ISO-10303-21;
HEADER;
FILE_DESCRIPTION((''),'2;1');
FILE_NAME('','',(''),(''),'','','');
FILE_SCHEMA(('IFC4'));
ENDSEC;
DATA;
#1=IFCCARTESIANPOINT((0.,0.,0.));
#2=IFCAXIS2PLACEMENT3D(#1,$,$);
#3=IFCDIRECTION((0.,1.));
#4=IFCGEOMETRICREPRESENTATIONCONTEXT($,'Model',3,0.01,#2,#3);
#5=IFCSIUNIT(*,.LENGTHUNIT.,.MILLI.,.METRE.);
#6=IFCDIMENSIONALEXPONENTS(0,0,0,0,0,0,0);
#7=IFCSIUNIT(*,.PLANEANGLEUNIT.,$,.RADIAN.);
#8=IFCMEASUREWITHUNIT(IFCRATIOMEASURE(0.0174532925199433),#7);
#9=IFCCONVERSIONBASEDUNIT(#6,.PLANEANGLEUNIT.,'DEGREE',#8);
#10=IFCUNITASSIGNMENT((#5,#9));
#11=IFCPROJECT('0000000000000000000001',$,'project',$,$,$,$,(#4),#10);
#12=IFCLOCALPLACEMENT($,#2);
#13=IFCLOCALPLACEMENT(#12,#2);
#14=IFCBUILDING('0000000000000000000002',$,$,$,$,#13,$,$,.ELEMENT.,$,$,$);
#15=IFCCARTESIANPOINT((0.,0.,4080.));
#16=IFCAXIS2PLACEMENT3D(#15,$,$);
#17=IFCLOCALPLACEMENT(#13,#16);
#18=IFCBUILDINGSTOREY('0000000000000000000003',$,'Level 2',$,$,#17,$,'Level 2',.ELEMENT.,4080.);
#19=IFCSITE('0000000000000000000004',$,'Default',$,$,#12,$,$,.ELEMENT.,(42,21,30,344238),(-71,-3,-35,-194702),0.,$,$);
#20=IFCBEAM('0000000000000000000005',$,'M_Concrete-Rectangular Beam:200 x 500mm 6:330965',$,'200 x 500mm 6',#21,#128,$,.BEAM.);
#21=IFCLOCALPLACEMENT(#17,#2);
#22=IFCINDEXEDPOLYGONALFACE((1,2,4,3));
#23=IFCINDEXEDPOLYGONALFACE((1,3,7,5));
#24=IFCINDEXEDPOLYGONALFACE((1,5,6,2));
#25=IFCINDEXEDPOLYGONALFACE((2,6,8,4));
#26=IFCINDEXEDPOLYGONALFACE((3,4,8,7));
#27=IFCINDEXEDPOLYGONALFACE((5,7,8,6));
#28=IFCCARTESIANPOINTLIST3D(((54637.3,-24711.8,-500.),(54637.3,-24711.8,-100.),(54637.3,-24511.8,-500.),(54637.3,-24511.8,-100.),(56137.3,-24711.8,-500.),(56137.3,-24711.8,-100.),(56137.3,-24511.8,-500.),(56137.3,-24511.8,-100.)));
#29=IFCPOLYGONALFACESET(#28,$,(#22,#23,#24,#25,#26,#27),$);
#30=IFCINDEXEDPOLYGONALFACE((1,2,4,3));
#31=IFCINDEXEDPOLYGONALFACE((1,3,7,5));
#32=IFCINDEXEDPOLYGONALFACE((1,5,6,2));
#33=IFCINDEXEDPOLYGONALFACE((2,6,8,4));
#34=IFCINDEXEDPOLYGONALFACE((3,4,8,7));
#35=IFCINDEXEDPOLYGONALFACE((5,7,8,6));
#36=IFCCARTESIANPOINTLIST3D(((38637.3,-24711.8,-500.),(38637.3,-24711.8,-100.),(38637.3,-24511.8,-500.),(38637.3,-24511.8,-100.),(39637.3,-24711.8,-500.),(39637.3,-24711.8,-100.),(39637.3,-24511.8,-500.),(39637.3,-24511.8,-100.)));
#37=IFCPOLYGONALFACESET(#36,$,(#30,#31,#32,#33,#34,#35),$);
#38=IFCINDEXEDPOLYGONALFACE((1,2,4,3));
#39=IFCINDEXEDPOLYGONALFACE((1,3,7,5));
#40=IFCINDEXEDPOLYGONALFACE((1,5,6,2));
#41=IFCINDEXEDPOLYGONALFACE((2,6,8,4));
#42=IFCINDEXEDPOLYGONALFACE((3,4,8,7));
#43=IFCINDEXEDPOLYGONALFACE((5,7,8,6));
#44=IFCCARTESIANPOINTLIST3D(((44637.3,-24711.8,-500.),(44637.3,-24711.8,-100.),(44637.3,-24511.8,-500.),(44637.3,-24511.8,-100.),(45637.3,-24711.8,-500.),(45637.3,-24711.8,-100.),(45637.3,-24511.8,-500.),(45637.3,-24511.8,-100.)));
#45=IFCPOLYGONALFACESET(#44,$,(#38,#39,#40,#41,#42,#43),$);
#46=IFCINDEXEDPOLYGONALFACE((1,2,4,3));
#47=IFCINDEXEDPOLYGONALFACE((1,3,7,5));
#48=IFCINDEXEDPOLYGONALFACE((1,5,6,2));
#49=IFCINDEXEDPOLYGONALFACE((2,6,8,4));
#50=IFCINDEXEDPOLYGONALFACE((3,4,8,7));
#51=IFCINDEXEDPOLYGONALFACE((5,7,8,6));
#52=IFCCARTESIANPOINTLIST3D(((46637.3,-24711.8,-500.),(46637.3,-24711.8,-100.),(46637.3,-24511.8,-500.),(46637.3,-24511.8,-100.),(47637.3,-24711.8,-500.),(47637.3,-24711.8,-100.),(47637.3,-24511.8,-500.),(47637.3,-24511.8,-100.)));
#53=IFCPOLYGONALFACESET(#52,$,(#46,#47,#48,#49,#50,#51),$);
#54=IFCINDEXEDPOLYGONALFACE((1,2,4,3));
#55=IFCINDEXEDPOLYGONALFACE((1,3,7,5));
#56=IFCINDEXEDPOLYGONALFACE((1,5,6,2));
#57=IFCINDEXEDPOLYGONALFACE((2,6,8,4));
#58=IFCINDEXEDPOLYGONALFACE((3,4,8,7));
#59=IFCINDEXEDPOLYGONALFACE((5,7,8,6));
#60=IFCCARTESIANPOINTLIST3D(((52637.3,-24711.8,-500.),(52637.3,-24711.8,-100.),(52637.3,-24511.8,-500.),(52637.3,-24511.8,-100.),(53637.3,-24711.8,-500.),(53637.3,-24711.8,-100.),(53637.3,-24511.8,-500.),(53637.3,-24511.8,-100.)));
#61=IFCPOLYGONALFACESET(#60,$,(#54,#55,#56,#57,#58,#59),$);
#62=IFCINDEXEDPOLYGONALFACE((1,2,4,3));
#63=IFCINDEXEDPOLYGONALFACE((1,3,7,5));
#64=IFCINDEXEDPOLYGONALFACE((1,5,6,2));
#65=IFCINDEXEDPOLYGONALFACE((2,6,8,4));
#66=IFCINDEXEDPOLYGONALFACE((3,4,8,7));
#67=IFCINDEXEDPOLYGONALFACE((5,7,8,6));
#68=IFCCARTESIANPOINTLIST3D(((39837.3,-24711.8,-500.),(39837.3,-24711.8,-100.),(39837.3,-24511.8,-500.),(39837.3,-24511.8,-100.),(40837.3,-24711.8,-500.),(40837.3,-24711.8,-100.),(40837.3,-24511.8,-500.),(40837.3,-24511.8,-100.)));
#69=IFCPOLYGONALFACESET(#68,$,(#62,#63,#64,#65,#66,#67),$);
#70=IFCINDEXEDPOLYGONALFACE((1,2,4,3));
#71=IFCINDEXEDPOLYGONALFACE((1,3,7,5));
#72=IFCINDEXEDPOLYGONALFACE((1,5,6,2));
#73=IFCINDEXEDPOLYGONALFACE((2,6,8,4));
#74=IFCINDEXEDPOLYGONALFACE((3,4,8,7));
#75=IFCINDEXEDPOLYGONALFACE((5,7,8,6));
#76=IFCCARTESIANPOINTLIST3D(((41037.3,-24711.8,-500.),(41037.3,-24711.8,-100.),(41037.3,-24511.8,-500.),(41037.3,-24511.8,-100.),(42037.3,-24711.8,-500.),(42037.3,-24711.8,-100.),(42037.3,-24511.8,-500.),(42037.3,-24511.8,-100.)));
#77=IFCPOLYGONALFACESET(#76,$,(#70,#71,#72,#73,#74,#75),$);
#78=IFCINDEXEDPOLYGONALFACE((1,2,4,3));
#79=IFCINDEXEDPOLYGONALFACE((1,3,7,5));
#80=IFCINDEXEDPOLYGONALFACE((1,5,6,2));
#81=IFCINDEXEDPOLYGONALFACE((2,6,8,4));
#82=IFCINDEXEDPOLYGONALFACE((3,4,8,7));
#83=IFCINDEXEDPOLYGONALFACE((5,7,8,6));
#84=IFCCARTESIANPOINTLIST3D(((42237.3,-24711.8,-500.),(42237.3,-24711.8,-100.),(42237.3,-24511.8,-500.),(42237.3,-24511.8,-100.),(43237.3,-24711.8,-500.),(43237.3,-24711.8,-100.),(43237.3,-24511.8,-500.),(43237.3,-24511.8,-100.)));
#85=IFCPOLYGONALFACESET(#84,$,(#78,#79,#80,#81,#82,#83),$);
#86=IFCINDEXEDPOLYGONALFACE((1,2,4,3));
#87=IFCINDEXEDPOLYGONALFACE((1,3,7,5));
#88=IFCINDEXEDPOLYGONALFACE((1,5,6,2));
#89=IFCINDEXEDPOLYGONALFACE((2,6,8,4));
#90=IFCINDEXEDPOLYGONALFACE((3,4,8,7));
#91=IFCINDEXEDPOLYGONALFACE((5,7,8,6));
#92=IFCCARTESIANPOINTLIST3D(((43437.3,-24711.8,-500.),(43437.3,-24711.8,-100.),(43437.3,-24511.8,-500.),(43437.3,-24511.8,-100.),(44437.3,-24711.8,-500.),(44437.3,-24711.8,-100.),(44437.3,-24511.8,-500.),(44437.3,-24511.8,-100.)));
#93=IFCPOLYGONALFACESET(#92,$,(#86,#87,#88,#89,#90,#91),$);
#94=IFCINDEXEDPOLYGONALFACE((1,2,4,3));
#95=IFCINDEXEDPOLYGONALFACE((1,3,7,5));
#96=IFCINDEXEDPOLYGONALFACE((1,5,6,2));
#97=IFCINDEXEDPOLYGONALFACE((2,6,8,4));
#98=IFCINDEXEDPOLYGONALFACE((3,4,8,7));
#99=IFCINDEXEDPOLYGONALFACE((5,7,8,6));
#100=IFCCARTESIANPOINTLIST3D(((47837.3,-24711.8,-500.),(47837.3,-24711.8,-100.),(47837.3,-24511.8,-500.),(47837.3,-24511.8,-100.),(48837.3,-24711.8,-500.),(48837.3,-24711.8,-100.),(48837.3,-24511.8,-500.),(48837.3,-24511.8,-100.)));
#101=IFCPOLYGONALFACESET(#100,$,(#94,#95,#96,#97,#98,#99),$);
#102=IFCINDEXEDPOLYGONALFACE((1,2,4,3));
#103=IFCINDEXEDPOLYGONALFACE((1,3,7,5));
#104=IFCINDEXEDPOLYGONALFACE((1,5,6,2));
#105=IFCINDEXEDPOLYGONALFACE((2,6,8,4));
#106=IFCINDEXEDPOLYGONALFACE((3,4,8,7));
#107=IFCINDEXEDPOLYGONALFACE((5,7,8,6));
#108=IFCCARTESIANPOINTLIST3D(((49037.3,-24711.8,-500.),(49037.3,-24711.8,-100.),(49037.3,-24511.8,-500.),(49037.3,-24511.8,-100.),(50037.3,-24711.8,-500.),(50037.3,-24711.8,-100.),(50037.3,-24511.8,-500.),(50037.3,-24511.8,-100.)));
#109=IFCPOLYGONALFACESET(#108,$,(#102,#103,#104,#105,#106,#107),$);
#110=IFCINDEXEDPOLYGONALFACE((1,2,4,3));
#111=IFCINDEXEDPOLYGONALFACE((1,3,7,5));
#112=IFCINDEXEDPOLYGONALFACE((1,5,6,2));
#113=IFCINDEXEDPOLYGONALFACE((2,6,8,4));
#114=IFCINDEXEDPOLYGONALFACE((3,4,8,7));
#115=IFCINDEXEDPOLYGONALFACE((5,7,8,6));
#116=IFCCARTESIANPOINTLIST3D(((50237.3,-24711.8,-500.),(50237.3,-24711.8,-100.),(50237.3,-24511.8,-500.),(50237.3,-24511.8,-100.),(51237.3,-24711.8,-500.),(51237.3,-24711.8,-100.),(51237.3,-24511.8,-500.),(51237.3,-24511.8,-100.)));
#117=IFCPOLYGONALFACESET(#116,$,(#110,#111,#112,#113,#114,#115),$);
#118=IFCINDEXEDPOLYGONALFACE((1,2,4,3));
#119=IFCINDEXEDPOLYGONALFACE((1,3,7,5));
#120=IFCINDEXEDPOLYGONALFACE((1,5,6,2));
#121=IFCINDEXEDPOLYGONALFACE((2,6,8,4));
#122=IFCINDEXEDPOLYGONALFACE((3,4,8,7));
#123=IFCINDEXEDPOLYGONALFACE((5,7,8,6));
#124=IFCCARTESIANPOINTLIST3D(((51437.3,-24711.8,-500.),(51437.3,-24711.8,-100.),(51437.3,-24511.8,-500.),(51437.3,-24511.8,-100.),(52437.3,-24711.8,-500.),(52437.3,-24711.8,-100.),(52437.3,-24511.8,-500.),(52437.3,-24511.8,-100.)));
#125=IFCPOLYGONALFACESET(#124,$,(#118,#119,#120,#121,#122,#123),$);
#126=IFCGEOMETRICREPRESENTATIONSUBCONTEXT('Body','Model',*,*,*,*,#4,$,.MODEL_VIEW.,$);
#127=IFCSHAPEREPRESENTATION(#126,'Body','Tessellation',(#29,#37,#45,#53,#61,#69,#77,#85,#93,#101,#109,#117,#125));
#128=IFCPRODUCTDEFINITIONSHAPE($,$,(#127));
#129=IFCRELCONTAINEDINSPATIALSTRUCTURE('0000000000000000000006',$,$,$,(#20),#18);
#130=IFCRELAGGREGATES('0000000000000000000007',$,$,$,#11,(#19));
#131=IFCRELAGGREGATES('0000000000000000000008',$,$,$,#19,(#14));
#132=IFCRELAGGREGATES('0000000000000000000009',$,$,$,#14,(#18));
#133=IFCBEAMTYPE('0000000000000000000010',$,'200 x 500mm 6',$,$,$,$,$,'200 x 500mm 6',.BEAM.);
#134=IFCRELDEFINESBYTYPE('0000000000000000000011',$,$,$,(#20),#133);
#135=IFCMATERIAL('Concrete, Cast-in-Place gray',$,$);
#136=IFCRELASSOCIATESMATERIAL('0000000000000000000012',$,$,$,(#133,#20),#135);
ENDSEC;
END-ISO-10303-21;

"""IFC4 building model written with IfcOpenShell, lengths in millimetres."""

from ifc_helpers import new_model, entity, si_unit, converted_unit, direction, frame, frame_2d, origin, place, context, subcontext, project, spatial, rectangle, extrude, source, transform, mapped, material, type_object, type_shapes, element, save


model = new_model("IFC4")

# Units and contexts
model_context = context("Model", 3, precision=0.01, world=origin(), true_north=direction((0.0, 1.0)))
body_context = subcontext(model_context, "Body", "Model", "MODEL_VIEW")
ifc_project = project(units=[si_unit("LENGTHUNIT", "METRE", prefix="MILLI"), converted_unit("PLANEANGLEUNIT", "DEGREE", entity("IfcRatioMeasure", 0.0174532925199433), si_unit("PLANEANGLEUNIT", "RADIAN"), dimensions=[0, 0, 0, 0, 0, 0, 0])], contexts=[model_context])

# Site, building, storey
site_placement = place(None, origin())
site = spatial("IfcSite", under=ifc_project, at=site_placement, Name="Default", CompositionType="ELEMENT", RefLatitude=(42, 21, 30, 344238), RefLongitude=(-71, -3, -35, -194702), RefElevation=0.0)
building_placement = place(site_placement, origin())
building = spatial("IfcBuilding", under=site, at=building_placement, CompositionType="ELEMENT")
storey_placement = place(building_placement, frame((0.0, 0.0, 4080.0)))
storey = spatial("IfcBuildingStorey", under=building, at=storey_placement, Name="Level 2", LongName="Level 2", CompositionType="ELEMENT", Elevation=4080.0)

# Beam
ifc_material_1 = material(Name="Concrete, Cast-in-Place gray")
beam_type_1 = type_object("IfcBeamType", Name="200 x 500mm 6", ElementType="200 x 500mm 6", PredefinedType="BEAM", material=ifc_material_1)
shared_shape_1 = source(origin(), body_context, "Body", "SweptSolid", [
    extrude(rectangle(XDim=1500.0, YDim=200.0, at=frame_2d((-175.0, 0.0), x_axis=(1.0, 0.0))), frame((55562.3, -24611.8, 3580.0)), (0.0, 0.0, 1.0), 400.0),
    extrude(rectangle(XDim=1000.0, YDim=200.0, at=frame_2d((0.0, 0.0), x_axis=(1.0, 0.0))), frame((39137.3, -24611.8, 3580.0)), (0.0, 0.0, 1.0), 400.0),
    extrude(rectangle(XDim=1000.0, YDim=200.0, at=frame_2d((0.0, 0.0), x_axis=(1.0, 0.0))), frame((45137.3, -24611.8, 3580.0), z_axis=(0.0, 0.0, 1.0), x_axis=(-1.0, 0.0, 0.0)), (0.0, 0.0, 1.0), 400.0),
    extrude(rectangle(XDim=1000.0, YDim=200.0, at=frame_2d((-133.3, 0.0), x_axis=(1.0, 0.0))), frame((47270.6, -24611.8, 3580.0)), (0.0, 0.0, 1.0), 400.0),
    extrude(rectangle(XDim=1000.0, YDim=200.0, at=frame_2d((0.0, 0.0), x_axis=(1.0, 0.0))), frame((53137.3, -24611.8, 3580.0), z_axis=(0.0, 0.0, 1.0), x_axis=(-1.0, 0.0, 0.0)), (0.0, 0.0, 1.0), 400.0),
    extrude(rectangle(XDim=1000.0, YDim=200.0, at=frame_2d((0.0, 0.0), x_axis=(1.0, 0.0))), frame((40337.3, -24611.8, 3580.0)), (0.0, 0.0, 1.0), 400.0),
    extrude(rectangle(XDim=1000.0, YDim=200.0, at=frame_2d((0.0, 0.0), x_axis=(1.0, 0.0))), frame((41537.3, -24611.8, 3580.0)), (0.0, 0.0, 1.0), 400.0),
    extrude(rectangle(XDim=1000.0, YDim=200.0, at=frame_2d((0.0, 0.0), x_axis=(1.0, 0.0))), frame((42737.3, -24611.8, 3580.0)), (0.0, 0.0, 1.0), 400.0),
    extrude(rectangle(XDim=1000.0, YDim=200.0, at=frame_2d((0.0, 0.0), x_axis=(1.0, 0.0))), frame((43937.3, -24611.8, 3580.0)), (0.0, 0.0, 1.0), 400.0),
    extrude(rectangle(XDim=1000.0, YDim=200.0, at=frame_2d((0.0, 0.0), x_axis=(1.0, 0.0))), frame((48337.3, -24611.8, 3580.0)), (0.0, 0.0, 1.0), 400.0),
    extrude(rectangle(XDim=1000.0, YDim=200.0, at=frame_2d((0.0, 0.0), x_axis=(1.0, 0.0))), frame((49537.3, -24611.8, 3580.0)), (0.0, 0.0, 1.0), 400.0),
    extrude(rectangle(XDim=1000.0, YDim=200.0, at=frame_2d((0.0, 0.0), x_axis=(1.0, 0.0))), frame((50737.3, -24611.8, 3580.0)), (0.0, 0.0, 1.0), 400.0),
    extrude(rectangle(XDim=1000.0, YDim=200.0, at=frame_2d((0.0, 0.0), x_axis=(1.0, 0.0))), frame((51937.3, -24611.8, 3580.0)), (0.0, 0.0, 1.0), 400.0),
])
type_shapes(beam_type_1, [shared_shape_1])
beam_1_placement = place(storey_placement, frame((0.0, 0.0, -4080.0)))
element("IfcBeam", 1, at=beam_1_placement, inside=storey, type_object=beam_type_1, material=ifc_material_1, Name="M_Concrete-Rectangular Beam:200 x 500mm 6:330965", ObjectType="200 x 500mm 6", PredefinedType="BEAM", context=body_context, shape_type="MappedRepresentation", body=[
    mapped(shared_shape_1, transform((0.0, 0.0, 0.0), scale=1.0)),
])

save(model, "model.ifc")
